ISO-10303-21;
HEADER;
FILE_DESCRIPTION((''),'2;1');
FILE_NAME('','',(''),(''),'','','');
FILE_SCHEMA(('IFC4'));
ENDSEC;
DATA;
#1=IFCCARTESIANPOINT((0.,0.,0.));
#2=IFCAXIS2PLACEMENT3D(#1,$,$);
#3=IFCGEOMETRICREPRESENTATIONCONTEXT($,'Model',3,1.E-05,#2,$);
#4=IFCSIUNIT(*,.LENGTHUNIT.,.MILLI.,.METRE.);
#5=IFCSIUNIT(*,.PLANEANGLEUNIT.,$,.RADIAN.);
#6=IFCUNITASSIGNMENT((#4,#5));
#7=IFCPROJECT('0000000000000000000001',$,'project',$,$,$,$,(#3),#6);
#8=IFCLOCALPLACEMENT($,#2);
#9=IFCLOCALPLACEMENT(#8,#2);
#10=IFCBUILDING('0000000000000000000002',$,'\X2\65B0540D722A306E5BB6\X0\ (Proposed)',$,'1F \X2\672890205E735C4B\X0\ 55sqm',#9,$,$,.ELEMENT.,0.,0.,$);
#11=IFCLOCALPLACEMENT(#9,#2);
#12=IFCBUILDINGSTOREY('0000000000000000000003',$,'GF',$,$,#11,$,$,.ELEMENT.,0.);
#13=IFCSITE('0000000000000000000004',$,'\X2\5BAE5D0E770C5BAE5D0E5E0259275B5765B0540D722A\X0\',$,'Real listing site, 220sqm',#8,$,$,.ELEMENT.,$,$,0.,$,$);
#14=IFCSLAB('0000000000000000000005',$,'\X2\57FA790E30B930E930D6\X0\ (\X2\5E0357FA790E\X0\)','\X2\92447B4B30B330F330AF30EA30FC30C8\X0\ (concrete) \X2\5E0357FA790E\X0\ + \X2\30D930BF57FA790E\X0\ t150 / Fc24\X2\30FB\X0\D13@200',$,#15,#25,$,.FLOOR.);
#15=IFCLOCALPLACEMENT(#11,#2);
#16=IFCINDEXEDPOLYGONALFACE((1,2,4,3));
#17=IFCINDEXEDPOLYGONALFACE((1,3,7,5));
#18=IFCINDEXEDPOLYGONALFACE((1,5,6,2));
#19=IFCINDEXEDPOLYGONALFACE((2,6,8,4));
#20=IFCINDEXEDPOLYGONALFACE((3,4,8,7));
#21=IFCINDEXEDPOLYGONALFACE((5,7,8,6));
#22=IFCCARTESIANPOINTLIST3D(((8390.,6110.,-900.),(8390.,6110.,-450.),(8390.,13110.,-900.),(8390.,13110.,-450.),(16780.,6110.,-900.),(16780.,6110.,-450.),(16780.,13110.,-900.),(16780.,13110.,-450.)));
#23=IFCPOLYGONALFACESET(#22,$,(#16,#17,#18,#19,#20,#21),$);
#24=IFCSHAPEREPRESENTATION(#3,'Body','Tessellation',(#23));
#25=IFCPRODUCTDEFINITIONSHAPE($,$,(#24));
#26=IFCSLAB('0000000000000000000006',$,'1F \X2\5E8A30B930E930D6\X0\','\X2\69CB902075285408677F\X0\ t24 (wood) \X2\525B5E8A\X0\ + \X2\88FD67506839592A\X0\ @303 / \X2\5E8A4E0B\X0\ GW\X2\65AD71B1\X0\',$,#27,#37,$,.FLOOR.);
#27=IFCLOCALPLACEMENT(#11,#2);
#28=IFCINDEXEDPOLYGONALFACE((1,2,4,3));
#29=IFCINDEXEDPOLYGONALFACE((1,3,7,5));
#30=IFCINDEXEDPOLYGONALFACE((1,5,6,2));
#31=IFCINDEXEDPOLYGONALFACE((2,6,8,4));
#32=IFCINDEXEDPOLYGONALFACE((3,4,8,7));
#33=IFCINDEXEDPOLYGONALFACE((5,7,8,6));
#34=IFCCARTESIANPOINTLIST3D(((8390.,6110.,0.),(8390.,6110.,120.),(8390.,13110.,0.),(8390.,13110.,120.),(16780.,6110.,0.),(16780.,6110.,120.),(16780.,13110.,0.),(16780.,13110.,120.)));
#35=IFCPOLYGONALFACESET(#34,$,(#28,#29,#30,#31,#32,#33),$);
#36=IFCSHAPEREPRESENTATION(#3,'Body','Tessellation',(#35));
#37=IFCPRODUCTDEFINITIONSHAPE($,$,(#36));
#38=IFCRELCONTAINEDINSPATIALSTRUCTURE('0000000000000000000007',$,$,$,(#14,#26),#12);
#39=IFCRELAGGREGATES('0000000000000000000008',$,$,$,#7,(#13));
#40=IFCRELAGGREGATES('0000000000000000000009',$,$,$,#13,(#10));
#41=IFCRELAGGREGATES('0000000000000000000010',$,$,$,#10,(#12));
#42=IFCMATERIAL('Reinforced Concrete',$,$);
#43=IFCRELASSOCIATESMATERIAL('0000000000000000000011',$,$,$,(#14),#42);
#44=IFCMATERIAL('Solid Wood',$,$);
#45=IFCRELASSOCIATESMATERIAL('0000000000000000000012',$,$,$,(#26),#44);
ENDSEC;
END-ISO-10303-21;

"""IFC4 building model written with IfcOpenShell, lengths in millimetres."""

from ifc_helpers import new_model, si_unit, frame, frame_2d, origin, place, context, project, spatial, rectangle, extrude, material, element, save


model = new_model("IFC4")

# Units and contexts
model_context = context("Model", 3, precision=1e-05, world=origin())
ifc_project = project(units=[si_unit("LENGTHUNIT", "METRE", prefix="MILLI"), si_unit("PLANEANGLEUNIT", "RADIAN")], contexts=[model_context])

# Site, building, storey
site_placement = place(None, origin())
site = spatial("IfcSite", under=ifc_project, at=site_placement, Name="宮崎県宮崎市大字新名爪", ObjectType="Real listing site, 220sqm", CompositionType="ELEMENT", RefElevation=0.0)
building_placement = place(site_placement, origin())
building = spatial("IfcBuilding", under=site, at=building_placement, Name="新名爪の家 (Proposed)", ObjectType="1F 木造平屋 55sqm", CompositionType="ELEMENT", ElevationOfRefHeight=0.0, ElevationOfTerrain=0.0)
storey_placement = place(building_placement, origin())
storey = spatial("IfcBuildingStorey", under=building, at=storey_placement, Name="GF", CompositionType="ELEMENT", Elevation=0.0)

# Shared definitions
ifc_material_1 = material(Name="Solid Wood")

# Slabs
ifc_material_2 = material(Name="Reinforced Concrete")
slab_1_placement = place(storey_placement, frame((4195.0, 3055.0, -450.0)))
element("IfcSlab", 1, at=slab_1_placement, inside=storey, material=ifc_material_2, Name="基礎スラブ (布基礎)", Description="鉄筋コンクリート (concrete) 布基礎 + ベタ基礎 t150 / Fc24・D13@200", PredefinedType="FLOOR", context=model_context, shape_type="SweptSolid", body=[
    extrude(rectangle(XDim=8390.0, YDim=7000.0, at=frame_2d((4195.0, 3500.0))), frame((4195.0, 3055.0, -450.0)), (0.0, 0.0, 1.0), 450.0),
])
slab_2_placement = place(storey_placement, frame((4195.0, 3055.0, 0.0)))
element("IfcSlab", 2, at=slab_2_placement, inside=storey, material=ifc_material_1, Name="1F 床スラブ", Description="構造用合板 t24 (wood) 剛床 + 製材根太 @303 / 床下 GW断熱", PredefinedType="FLOOR", context=model_context, shape_type="SweptSolid", body=[
    extrude(rectangle(XDim=8390.0, YDim=7000.0, at=frame_2d((4195.0, 3500.0))), frame((4195.0, 3055.0, 0.0)), (0.0, 0.0, 1.0), 120.0),
])

save(model, "model.ifc")
